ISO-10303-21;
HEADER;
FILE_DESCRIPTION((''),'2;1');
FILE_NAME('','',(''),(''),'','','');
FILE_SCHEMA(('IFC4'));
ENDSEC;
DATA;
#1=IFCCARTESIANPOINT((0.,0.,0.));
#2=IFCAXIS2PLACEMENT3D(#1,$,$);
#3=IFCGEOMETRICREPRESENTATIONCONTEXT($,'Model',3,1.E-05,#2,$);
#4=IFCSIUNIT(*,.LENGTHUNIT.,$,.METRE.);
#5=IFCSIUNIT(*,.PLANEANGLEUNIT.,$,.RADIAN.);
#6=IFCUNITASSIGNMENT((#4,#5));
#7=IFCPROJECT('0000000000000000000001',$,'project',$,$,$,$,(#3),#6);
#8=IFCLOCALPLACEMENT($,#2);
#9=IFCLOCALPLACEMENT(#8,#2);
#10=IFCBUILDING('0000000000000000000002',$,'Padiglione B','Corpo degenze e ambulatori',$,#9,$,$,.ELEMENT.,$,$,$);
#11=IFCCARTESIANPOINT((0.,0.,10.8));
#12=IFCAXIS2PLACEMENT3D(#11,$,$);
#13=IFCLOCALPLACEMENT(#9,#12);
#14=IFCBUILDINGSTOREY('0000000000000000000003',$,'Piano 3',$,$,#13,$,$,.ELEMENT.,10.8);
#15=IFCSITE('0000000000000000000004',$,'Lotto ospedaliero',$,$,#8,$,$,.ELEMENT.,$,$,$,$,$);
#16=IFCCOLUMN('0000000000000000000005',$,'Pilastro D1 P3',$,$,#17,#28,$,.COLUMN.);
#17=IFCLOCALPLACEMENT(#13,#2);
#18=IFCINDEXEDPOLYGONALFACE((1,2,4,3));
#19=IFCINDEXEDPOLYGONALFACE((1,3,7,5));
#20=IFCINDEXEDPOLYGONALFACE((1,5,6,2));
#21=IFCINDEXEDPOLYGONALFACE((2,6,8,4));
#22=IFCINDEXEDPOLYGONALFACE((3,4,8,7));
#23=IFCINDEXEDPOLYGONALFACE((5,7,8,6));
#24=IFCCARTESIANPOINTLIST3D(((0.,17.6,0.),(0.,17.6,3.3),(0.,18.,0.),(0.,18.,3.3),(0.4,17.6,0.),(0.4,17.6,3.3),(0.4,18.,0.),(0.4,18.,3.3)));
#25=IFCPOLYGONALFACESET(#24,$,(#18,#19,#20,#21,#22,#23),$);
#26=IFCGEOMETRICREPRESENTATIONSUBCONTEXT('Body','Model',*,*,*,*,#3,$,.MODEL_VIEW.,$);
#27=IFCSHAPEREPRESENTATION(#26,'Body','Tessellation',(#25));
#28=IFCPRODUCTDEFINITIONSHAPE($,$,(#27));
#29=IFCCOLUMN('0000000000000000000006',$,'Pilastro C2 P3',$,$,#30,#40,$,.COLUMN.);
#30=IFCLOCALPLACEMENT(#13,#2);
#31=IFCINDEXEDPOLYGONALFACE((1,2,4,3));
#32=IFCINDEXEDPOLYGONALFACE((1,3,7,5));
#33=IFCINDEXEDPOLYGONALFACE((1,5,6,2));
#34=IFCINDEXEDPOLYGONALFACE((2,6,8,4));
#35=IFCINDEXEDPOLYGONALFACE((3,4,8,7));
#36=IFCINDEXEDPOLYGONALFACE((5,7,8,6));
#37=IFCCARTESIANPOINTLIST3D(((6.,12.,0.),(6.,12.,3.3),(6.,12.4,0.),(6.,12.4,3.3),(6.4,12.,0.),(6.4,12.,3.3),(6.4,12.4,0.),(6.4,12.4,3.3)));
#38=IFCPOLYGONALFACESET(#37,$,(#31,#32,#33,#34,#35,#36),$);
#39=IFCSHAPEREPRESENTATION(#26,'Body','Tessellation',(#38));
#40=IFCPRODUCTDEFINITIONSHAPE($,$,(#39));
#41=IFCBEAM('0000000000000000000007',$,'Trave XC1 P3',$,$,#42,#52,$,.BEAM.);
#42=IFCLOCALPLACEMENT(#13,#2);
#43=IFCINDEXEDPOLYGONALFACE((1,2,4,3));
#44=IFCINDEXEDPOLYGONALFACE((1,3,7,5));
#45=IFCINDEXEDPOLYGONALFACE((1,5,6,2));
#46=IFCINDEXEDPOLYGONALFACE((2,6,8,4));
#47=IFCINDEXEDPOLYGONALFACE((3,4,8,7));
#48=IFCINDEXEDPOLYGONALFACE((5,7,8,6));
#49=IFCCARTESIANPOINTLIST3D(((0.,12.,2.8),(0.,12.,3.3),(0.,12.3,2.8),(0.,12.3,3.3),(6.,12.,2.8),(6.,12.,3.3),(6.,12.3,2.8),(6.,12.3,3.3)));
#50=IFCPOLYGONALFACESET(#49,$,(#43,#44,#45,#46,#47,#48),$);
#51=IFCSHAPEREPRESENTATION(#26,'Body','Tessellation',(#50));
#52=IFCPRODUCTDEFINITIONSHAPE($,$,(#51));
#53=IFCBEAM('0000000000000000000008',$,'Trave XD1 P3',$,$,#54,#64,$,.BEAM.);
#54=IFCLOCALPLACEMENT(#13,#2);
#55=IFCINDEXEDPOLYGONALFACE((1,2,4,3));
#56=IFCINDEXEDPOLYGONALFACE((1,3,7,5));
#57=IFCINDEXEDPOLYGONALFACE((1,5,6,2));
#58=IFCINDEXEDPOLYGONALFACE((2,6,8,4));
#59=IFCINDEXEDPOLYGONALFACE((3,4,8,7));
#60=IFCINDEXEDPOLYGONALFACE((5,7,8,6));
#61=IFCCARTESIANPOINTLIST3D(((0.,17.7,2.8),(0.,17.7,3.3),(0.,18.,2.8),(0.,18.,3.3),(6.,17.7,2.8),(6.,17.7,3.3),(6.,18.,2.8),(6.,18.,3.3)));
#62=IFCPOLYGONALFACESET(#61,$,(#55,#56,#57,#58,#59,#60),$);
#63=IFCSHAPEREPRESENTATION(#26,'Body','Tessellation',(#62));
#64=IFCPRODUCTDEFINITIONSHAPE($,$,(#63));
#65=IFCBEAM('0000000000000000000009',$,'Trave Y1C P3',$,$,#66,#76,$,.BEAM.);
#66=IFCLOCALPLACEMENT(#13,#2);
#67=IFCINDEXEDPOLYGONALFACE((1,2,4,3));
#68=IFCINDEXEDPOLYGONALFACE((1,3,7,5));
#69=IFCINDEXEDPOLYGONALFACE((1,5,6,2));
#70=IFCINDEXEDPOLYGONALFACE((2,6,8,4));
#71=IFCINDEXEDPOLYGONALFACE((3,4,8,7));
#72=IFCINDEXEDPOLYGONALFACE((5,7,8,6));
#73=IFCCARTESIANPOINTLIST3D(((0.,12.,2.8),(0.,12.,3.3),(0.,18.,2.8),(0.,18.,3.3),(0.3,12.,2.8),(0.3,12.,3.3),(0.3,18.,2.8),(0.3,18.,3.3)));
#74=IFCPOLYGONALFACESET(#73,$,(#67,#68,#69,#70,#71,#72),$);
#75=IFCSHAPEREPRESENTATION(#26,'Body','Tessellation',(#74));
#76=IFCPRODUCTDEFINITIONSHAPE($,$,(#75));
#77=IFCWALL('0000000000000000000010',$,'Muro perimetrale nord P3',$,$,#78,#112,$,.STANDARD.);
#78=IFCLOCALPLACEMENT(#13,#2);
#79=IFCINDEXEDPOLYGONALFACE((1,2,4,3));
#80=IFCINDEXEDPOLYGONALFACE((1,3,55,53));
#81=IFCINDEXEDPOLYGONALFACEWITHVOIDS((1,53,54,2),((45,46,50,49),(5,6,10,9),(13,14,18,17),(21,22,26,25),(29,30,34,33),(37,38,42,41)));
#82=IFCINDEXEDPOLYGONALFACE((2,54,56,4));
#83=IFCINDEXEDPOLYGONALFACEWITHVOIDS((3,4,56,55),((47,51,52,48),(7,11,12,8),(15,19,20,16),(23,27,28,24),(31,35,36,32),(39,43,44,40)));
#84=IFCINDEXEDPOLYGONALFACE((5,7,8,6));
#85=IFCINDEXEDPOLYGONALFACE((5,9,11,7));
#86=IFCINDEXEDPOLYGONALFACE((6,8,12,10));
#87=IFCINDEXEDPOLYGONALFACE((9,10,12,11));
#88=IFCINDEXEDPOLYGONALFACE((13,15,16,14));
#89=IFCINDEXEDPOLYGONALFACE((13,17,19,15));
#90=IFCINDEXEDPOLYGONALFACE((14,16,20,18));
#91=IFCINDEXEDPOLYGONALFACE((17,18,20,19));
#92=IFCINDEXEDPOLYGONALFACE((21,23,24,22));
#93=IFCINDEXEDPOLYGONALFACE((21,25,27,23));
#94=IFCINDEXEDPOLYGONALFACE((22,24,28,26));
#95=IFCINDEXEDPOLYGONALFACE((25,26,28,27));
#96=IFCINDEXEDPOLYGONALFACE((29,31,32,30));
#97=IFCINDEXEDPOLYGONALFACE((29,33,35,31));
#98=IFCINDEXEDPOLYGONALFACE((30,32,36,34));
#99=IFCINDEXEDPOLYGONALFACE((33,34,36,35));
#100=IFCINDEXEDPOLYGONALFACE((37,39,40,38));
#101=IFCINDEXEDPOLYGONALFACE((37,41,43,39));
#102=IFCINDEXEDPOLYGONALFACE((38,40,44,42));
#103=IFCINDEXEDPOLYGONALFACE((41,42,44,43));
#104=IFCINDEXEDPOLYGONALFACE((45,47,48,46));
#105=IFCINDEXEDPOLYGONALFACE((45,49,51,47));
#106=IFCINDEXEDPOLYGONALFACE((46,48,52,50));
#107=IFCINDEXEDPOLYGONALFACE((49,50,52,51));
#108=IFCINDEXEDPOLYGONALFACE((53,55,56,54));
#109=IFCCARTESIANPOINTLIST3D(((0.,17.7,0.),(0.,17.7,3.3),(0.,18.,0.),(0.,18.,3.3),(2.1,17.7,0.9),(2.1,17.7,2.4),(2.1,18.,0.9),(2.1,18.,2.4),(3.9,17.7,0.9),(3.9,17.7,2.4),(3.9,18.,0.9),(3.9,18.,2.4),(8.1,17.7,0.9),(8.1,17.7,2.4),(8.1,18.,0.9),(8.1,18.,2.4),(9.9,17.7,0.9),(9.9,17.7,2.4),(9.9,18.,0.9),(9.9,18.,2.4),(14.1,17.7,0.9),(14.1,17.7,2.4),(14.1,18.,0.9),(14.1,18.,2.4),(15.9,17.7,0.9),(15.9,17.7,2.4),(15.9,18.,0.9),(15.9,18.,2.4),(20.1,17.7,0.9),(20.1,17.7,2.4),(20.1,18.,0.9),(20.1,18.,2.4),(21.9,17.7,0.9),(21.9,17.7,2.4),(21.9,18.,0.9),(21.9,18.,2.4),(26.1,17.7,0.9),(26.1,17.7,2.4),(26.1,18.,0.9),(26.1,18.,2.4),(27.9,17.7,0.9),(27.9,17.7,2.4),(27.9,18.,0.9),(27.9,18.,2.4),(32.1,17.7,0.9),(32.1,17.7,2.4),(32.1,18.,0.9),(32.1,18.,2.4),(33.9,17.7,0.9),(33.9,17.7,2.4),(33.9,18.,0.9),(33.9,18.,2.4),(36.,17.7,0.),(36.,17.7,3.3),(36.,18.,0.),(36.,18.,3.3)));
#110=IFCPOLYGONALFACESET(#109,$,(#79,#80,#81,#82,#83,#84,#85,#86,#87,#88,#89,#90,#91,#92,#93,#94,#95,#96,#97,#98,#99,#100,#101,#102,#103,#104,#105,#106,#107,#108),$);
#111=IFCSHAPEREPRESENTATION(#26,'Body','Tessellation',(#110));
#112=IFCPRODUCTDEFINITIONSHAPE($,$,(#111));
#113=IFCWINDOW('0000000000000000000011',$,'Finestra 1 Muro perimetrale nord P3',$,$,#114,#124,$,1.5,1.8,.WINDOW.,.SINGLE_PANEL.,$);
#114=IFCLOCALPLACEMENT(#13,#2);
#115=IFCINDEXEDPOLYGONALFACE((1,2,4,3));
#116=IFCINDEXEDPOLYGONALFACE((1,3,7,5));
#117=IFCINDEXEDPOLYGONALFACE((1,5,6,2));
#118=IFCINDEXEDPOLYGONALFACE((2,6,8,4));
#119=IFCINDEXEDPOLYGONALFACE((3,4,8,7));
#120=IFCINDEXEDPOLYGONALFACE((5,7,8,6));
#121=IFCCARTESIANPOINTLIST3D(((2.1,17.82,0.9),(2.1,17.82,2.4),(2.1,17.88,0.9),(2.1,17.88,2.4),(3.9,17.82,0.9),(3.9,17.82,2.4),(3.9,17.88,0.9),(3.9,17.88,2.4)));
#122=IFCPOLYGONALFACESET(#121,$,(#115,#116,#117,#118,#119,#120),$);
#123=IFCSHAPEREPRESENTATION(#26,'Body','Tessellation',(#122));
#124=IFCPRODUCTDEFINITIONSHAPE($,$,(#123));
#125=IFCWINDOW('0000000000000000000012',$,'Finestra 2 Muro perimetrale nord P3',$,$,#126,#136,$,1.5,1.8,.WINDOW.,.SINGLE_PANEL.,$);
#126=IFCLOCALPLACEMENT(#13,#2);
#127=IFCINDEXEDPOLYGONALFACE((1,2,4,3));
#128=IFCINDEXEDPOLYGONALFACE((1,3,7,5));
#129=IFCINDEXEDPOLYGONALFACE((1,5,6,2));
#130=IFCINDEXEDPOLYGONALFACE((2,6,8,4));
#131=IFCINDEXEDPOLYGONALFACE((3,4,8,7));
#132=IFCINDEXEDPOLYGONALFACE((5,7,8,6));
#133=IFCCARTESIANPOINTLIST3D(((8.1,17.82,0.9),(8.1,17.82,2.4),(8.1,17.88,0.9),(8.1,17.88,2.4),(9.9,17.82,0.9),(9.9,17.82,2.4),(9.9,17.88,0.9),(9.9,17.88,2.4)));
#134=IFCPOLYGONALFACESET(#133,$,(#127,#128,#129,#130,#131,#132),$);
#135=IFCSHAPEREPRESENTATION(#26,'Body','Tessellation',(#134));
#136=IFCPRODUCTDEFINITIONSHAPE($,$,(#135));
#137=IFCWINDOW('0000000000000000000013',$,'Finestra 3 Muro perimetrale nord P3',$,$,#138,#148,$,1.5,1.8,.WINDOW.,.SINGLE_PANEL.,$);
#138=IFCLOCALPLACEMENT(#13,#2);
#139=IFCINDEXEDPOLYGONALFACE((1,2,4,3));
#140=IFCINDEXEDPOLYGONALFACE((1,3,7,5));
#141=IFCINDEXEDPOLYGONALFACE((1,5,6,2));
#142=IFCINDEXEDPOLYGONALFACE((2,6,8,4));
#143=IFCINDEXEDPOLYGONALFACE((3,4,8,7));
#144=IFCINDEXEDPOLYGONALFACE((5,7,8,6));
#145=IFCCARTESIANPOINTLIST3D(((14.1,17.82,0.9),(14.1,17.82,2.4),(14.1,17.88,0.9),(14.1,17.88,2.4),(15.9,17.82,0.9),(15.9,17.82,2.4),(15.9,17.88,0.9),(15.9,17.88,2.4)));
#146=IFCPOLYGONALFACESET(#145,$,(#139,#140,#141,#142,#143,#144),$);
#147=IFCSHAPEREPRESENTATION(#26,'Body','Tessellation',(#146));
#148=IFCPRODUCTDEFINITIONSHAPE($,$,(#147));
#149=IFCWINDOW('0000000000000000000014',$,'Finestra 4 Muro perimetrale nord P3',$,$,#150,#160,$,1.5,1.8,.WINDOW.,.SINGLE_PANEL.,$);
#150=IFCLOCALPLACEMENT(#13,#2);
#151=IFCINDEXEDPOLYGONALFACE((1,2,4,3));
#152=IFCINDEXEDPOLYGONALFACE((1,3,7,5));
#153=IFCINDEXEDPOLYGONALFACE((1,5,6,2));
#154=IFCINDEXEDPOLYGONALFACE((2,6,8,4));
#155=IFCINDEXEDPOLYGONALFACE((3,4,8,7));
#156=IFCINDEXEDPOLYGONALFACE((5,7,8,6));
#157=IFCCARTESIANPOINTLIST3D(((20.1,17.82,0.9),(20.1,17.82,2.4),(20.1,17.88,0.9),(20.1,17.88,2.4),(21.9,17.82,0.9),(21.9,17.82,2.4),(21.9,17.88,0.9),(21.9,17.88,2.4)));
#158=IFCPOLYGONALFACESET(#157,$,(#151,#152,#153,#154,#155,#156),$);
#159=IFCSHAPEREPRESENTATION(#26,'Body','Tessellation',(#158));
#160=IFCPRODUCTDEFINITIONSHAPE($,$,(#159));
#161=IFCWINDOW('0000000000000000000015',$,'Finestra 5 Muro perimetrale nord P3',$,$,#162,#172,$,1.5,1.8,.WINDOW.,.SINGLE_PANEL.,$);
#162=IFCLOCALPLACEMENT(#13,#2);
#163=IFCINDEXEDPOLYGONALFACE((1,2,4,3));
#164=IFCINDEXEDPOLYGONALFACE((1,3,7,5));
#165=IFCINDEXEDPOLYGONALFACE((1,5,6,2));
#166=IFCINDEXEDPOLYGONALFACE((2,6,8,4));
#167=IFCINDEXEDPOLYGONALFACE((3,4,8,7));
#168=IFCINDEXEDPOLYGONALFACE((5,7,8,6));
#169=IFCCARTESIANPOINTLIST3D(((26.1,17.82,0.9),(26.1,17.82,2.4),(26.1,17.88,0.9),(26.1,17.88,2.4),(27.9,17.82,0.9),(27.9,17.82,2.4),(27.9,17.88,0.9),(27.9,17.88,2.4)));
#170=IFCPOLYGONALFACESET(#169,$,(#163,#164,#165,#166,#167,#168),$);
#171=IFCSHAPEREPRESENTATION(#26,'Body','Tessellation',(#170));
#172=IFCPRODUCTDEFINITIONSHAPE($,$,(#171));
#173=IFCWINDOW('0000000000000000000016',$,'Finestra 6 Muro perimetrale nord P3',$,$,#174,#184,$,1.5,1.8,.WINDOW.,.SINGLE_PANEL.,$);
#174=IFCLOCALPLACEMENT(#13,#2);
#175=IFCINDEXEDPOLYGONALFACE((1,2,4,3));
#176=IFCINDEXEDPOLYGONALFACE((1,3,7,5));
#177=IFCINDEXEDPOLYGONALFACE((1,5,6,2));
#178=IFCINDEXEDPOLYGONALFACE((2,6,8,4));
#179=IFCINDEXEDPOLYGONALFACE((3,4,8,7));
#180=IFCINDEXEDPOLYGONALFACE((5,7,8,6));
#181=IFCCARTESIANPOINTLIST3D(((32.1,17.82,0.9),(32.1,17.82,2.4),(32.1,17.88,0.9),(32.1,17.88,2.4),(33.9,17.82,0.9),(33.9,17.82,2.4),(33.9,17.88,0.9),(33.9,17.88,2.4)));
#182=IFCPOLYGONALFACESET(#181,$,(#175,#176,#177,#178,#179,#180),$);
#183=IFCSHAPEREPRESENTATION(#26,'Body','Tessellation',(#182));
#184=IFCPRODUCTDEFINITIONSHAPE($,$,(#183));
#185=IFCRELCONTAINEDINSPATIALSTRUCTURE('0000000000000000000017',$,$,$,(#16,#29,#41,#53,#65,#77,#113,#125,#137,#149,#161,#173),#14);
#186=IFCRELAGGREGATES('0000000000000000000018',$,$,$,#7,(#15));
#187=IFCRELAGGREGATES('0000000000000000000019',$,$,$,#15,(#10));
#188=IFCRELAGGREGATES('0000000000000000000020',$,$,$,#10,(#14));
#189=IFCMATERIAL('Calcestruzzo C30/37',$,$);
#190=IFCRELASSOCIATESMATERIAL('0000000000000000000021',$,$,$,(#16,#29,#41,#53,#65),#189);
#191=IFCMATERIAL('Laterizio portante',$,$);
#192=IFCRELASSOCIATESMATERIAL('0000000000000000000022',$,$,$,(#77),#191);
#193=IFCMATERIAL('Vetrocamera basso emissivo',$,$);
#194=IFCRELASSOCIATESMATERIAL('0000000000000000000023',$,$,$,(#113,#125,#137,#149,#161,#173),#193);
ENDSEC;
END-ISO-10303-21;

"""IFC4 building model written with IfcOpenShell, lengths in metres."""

from ifc_helpers import new_model, si_unit, frame, frame_2d, origin, place, context, subcontext, project, spatial, rectangle, extrude, material, element, fill, save


model = new_model("IFC4")

# Units and contexts
model_context = context("Model", 3, precision=1e-05, world=origin())
body_context = subcontext(model_context, "Body", "Model", "MODEL_VIEW")
ifc_project = project(units=[si_unit("LENGTHUNIT", "METRE"), si_unit("PLANEANGLEUNIT", "RADIAN")], contexts=[model_context])

# Site, building, storey
site_placement = place(None, origin())
site = spatial("IfcSite", under=ifc_project, at=site_placement, Name="Lotto ospedaliero", CompositionType="ELEMENT")
building_placement = place(site_placement, origin())
building = spatial("IfcBuilding", under=site, at=building_placement, Name="Padiglione B", Description="Corpo degenze e ambulatori", CompositionType="ELEMENT")
storey_placement = place(building_placement, frame((0.0, 0.0, 10.8)))
storey = spatial("IfcBuildingStorey", under=building, at=storey_placement, Name="Piano 3", CompositionType="ELEMENT", Elevation=10.8)

# Columns
ifc_material_1 = material(Name="Calcestruzzo C30/37")
for number, where, name in (
    (1, (0.0, 17.6, 0.0), "Pilastro D1 P3"),
    (2, (6.0, 12.0, 0.0), "Pilastro C2 P3"),
):
    element("IfcColumn", number, at=place(storey_placement, frame(where)), inside=storey, material=ifc_material_1, Name=name, PredefinedType="COLUMN", context=body_context, shape_type="SweptSolid", body=[
        extrude(rectangle(XDim=0.4, YDim=0.4, at=frame_2d((0.2, 0.2))), origin(), (0.0, 0.0, 1.0), 3.3),
    ])

# Beams
for number, where, name in (
    (3, (0.0, 12.0, 2.8), "Trave XC1 P3"),
    (4, (0.0, 17.7, 2.8), "Trave XD1 P3"),
):
    element("IfcBeam", number, at=place(storey_placement, frame(where)), inside=storey, material=ifc_material_1, Name=name, PredefinedType="BEAM", context=body_context, shape_type="SweptSolid", body=[
        extrude(rectangle(XDim=6.0, YDim=0.3, at=frame_2d((3.0, 0.15))), origin(), (0.0, 0.0, 1.0), 0.5),
    ])
beam_placement = place(storey_placement, frame((0.0, 12.0, 2.8)))
element("IfcBeam", 5, at=beam_placement, inside=storey, material=ifc_material_1, Name="Trave Y1C P3", PredefinedType="BEAM", context=body_context, shape_type="SweptSolid", body=[
    extrude(rectangle(XDim=0.3, YDim=6.0, at=frame_2d((0.15, 3.0))), origin(), (0.0, 0.0, 1.0), 0.5),
])

# Wall, openings, windows
ifc_material_2 = material(Name="Laterizio portante")
wall_placement = place(storey_placement, frame((0.0, 17.7, 0.0)))
wall = element("IfcWall", 6, at=wall_placement, inside=storey, material=ifc_material_2, Name="Muro perimetrale nord P3", PredefinedType="STANDARD", context=body_context, shape_type="SweptSolid", body=[
    extrude(rectangle(XDim=36.0, YDim=0.3, at=frame_2d((18.0, 0.15))), origin(), (0.0, 0.0, 1.0), 3.3),
])
opening_1_placement = place(wall_placement, frame((2.1, -0.1, 0.9)))
opening_1 = element("IfcOpeningElement", 7, at=opening_1_placement, cuts=wall, PredefinedType="OPENING", context=body_context, shape_type="SweptSolid", body=[
    extrude(rectangle(XDim=1.8, YDim=0.5, at=frame_2d((0.9, 0.25))), origin(), (0.0, 0.0, 1.0), 1.5),
])
opening_2_placement = place(wall_placement, frame((8.1, -0.1, 0.9)))
opening_2 = element("IfcOpeningElement", 8, at=opening_2_placement, cuts=wall, PredefinedType="OPENING", context=body_context, shape_type="SweptSolid", body=[
    extrude(rectangle(XDim=1.8, YDim=0.5, at=frame_2d((0.9, 0.25))), origin(), (0.0, 0.0, 1.0), 1.5),
])
opening_3_placement = place(wall_placement, frame((14.1, -0.1, 0.9)))
opening_3 = element("IfcOpeningElement", 9, at=opening_3_placement, cuts=wall, PredefinedType="OPENING", context=body_context, shape_type="SweptSolid", body=[
    extrude(rectangle(XDim=1.8, YDim=0.5, at=frame_2d((0.9, 0.25))), origin(), (0.0, 0.0, 1.0), 1.5),
])
opening_4_placement = place(wall_placement, frame((20.1, -0.1, 0.9)))
opening_4 = element("IfcOpeningElement", 10, at=opening_4_placement, cuts=wall, PredefinedType="OPENING", context=body_context, shape_type="SweptSolid", body=[
    extrude(rectangle(XDim=1.8, YDim=0.5, at=frame_2d((0.9, 0.25))), origin(), (0.0, 0.0, 1.0), 1.5),
])
opening_5_placement = place(wall_placement, frame((26.1, -0.1, 0.9)))
opening_5 = element("IfcOpeningElement", 11, at=opening_5_placement, cuts=wall, PredefinedType="OPENING", context=body_context, shape_type="SweptSolid", body=[
    extrude(rectangle(XDim=1.8, YDim=0.5, at=frame_2d((0.9, 0.25))), origin(), (0.0, 0.0, 1.0), 1.5),
])
opening_6_placement = place(wall_placement, frame((32.1, -0.1, 0.9)))
opening_6 = element("IfcOpeningElement", 12, at=opening_6_placement, cuts=wall, PredefinedType="OPENING", context=body_context, shape_type="SweptSolid", body=[
    extrude(rectangle(XDim=1.8, YDim=0.5, at=frame_2d((0.9, 0.25))), origin(), (0.0, 0.0, 1.0), 1.5),
])
ifc_material_3 = material(Name="Vetrocamera basso emissivo")
window_1_placement = place(wall_placement, frame((2.1, 0.12, 0.9)))
window_1 = element("IfcWindow", 13, at=window_1_placement, inside=storey, material=ifc_material_3, Name="Finestra 1 Muro perimetrale nord P3", OverallHeight=1.5, OverallWidth=1.8, PartitioningType="SINGLE_PANEL", PredefinedType="WINDOW", context=body_context, shape_type="SweptSolid", body=[
    extrude(rectangle(XDim=1.8, YDim=0.06, at=frame_2d((0.9, 0.03))), origin(), (0.0, 0.0, 1.0), 1.5),
])
fill(opening_1, window_1)
window_2_placement = place(wall_placement, frame((8.1, 0.12, 0.9)))
window_2 = element("IfcWindow", 14, at=window_2_placement, inside=storey, material=ifc_material_3, Name="Finestra 2 Muro perimetrale nord P3", OverallHeight=1.5, OverallWidth=1.8, PartitioningType="SINGLE_PANEL", PredefinedType="WINDOW", context=body_context, shape_type="SweptSolid", body=[
    extrude(rectangle(XDim=1.8, YDim=0.06, at=frame_2d((0.9, 0.03))), origin(), (0.0, 0.0, 1.0), 1.5),
])
fill(opening_2, window_2)
window_3_placement = place(wall_placement, frame((14.1, 0.12, 0.9)))
window_3 = element("IfcWindow", 15, at=window_3_placement, inside=storey, material=ifc_material_3, Name="Finestra 3 Muro perimetrale nord P3", OverallHeight=1.5, OverallWidth=1.8, PartitioningType="SINGLE_PANEL", PredefinedType="WINDOW", context=body_context, shape_type="SweptSolid", body=[
    extrude(rectangle(XDim=1.8, YDim=0.06, at=frame_2d((0.9, 0.03))), origin(), (0.0, 0.0, 1.0), 1.5),
])
fill(opening_3, window_3)
window_4_placement = place(wall_placement, frame((20.1, 0.12, 0.9)))
window_4 = element("IfcWindow", 16, at=window_4_placement, inside=storey, material=ifc_material_3, Name="Finestra 4 Muro perimetrale nord P3", OverallHeight=1.5, OverallWidth=1.8, PartitioningType="SINGLE_PANEL", PredefinedType="WINDOW", context=body_context, shape_type="SweptSolid", body=[
    extrude(rectangle(XDim=1.8, YDim=0.06, at=frame_2d((0.9, 0.03))), origin(), (0.0, 0.0, 1.0), 1.5),
])
fill(opening_4, window_4)
window_5_placement = place(wall_placement, frame((26.1, 0.12, 0.9)))
window_5 = element("IfcWindow", 17, at=window_5_placement, inside=storey, material=ifc_material_3, Name="Finestra 5 Muro perimetrale nord P3", OverallHeight=1.5, OverallWidth=1.8, PartitioningType="SINGLE_PANEL", PredefinedType="WINDOW", context=body_context, shape_type="SweptSolid", body=[
    extrude(rectangle(XDim=1.8, YDim=0.06, at=frame_2d((0.9, 0.03))), origin(), (0.0, 0.0, 1.0), 1.5),
])
fill(opening_5, window_5)
window_6_placement = place(wall_placement, frame((32.1, 0.12, 0.9)))
window_6 = element("IfcWindow", 18, at=window_6_placement, inside=storey, material=ifc_material_3, Name="Finestra 6 Muro perimetrale nord P3", OverallHeight=1.5, OverallWidth=1.8, PartitioningType="SINGLE_PANEL", PredefinedType="WINDOW", context=body_context, shape_type="SweptSolid", body=[
    extrude(rectangle(XDim=1.8, YDim=0.06, at=frame_2d((0.9, 0.03))), origin(), (0.0, 0.0, 1.0), 1.5),
])
fill(opening_6, window_6)

save(model, "model.ifc")
